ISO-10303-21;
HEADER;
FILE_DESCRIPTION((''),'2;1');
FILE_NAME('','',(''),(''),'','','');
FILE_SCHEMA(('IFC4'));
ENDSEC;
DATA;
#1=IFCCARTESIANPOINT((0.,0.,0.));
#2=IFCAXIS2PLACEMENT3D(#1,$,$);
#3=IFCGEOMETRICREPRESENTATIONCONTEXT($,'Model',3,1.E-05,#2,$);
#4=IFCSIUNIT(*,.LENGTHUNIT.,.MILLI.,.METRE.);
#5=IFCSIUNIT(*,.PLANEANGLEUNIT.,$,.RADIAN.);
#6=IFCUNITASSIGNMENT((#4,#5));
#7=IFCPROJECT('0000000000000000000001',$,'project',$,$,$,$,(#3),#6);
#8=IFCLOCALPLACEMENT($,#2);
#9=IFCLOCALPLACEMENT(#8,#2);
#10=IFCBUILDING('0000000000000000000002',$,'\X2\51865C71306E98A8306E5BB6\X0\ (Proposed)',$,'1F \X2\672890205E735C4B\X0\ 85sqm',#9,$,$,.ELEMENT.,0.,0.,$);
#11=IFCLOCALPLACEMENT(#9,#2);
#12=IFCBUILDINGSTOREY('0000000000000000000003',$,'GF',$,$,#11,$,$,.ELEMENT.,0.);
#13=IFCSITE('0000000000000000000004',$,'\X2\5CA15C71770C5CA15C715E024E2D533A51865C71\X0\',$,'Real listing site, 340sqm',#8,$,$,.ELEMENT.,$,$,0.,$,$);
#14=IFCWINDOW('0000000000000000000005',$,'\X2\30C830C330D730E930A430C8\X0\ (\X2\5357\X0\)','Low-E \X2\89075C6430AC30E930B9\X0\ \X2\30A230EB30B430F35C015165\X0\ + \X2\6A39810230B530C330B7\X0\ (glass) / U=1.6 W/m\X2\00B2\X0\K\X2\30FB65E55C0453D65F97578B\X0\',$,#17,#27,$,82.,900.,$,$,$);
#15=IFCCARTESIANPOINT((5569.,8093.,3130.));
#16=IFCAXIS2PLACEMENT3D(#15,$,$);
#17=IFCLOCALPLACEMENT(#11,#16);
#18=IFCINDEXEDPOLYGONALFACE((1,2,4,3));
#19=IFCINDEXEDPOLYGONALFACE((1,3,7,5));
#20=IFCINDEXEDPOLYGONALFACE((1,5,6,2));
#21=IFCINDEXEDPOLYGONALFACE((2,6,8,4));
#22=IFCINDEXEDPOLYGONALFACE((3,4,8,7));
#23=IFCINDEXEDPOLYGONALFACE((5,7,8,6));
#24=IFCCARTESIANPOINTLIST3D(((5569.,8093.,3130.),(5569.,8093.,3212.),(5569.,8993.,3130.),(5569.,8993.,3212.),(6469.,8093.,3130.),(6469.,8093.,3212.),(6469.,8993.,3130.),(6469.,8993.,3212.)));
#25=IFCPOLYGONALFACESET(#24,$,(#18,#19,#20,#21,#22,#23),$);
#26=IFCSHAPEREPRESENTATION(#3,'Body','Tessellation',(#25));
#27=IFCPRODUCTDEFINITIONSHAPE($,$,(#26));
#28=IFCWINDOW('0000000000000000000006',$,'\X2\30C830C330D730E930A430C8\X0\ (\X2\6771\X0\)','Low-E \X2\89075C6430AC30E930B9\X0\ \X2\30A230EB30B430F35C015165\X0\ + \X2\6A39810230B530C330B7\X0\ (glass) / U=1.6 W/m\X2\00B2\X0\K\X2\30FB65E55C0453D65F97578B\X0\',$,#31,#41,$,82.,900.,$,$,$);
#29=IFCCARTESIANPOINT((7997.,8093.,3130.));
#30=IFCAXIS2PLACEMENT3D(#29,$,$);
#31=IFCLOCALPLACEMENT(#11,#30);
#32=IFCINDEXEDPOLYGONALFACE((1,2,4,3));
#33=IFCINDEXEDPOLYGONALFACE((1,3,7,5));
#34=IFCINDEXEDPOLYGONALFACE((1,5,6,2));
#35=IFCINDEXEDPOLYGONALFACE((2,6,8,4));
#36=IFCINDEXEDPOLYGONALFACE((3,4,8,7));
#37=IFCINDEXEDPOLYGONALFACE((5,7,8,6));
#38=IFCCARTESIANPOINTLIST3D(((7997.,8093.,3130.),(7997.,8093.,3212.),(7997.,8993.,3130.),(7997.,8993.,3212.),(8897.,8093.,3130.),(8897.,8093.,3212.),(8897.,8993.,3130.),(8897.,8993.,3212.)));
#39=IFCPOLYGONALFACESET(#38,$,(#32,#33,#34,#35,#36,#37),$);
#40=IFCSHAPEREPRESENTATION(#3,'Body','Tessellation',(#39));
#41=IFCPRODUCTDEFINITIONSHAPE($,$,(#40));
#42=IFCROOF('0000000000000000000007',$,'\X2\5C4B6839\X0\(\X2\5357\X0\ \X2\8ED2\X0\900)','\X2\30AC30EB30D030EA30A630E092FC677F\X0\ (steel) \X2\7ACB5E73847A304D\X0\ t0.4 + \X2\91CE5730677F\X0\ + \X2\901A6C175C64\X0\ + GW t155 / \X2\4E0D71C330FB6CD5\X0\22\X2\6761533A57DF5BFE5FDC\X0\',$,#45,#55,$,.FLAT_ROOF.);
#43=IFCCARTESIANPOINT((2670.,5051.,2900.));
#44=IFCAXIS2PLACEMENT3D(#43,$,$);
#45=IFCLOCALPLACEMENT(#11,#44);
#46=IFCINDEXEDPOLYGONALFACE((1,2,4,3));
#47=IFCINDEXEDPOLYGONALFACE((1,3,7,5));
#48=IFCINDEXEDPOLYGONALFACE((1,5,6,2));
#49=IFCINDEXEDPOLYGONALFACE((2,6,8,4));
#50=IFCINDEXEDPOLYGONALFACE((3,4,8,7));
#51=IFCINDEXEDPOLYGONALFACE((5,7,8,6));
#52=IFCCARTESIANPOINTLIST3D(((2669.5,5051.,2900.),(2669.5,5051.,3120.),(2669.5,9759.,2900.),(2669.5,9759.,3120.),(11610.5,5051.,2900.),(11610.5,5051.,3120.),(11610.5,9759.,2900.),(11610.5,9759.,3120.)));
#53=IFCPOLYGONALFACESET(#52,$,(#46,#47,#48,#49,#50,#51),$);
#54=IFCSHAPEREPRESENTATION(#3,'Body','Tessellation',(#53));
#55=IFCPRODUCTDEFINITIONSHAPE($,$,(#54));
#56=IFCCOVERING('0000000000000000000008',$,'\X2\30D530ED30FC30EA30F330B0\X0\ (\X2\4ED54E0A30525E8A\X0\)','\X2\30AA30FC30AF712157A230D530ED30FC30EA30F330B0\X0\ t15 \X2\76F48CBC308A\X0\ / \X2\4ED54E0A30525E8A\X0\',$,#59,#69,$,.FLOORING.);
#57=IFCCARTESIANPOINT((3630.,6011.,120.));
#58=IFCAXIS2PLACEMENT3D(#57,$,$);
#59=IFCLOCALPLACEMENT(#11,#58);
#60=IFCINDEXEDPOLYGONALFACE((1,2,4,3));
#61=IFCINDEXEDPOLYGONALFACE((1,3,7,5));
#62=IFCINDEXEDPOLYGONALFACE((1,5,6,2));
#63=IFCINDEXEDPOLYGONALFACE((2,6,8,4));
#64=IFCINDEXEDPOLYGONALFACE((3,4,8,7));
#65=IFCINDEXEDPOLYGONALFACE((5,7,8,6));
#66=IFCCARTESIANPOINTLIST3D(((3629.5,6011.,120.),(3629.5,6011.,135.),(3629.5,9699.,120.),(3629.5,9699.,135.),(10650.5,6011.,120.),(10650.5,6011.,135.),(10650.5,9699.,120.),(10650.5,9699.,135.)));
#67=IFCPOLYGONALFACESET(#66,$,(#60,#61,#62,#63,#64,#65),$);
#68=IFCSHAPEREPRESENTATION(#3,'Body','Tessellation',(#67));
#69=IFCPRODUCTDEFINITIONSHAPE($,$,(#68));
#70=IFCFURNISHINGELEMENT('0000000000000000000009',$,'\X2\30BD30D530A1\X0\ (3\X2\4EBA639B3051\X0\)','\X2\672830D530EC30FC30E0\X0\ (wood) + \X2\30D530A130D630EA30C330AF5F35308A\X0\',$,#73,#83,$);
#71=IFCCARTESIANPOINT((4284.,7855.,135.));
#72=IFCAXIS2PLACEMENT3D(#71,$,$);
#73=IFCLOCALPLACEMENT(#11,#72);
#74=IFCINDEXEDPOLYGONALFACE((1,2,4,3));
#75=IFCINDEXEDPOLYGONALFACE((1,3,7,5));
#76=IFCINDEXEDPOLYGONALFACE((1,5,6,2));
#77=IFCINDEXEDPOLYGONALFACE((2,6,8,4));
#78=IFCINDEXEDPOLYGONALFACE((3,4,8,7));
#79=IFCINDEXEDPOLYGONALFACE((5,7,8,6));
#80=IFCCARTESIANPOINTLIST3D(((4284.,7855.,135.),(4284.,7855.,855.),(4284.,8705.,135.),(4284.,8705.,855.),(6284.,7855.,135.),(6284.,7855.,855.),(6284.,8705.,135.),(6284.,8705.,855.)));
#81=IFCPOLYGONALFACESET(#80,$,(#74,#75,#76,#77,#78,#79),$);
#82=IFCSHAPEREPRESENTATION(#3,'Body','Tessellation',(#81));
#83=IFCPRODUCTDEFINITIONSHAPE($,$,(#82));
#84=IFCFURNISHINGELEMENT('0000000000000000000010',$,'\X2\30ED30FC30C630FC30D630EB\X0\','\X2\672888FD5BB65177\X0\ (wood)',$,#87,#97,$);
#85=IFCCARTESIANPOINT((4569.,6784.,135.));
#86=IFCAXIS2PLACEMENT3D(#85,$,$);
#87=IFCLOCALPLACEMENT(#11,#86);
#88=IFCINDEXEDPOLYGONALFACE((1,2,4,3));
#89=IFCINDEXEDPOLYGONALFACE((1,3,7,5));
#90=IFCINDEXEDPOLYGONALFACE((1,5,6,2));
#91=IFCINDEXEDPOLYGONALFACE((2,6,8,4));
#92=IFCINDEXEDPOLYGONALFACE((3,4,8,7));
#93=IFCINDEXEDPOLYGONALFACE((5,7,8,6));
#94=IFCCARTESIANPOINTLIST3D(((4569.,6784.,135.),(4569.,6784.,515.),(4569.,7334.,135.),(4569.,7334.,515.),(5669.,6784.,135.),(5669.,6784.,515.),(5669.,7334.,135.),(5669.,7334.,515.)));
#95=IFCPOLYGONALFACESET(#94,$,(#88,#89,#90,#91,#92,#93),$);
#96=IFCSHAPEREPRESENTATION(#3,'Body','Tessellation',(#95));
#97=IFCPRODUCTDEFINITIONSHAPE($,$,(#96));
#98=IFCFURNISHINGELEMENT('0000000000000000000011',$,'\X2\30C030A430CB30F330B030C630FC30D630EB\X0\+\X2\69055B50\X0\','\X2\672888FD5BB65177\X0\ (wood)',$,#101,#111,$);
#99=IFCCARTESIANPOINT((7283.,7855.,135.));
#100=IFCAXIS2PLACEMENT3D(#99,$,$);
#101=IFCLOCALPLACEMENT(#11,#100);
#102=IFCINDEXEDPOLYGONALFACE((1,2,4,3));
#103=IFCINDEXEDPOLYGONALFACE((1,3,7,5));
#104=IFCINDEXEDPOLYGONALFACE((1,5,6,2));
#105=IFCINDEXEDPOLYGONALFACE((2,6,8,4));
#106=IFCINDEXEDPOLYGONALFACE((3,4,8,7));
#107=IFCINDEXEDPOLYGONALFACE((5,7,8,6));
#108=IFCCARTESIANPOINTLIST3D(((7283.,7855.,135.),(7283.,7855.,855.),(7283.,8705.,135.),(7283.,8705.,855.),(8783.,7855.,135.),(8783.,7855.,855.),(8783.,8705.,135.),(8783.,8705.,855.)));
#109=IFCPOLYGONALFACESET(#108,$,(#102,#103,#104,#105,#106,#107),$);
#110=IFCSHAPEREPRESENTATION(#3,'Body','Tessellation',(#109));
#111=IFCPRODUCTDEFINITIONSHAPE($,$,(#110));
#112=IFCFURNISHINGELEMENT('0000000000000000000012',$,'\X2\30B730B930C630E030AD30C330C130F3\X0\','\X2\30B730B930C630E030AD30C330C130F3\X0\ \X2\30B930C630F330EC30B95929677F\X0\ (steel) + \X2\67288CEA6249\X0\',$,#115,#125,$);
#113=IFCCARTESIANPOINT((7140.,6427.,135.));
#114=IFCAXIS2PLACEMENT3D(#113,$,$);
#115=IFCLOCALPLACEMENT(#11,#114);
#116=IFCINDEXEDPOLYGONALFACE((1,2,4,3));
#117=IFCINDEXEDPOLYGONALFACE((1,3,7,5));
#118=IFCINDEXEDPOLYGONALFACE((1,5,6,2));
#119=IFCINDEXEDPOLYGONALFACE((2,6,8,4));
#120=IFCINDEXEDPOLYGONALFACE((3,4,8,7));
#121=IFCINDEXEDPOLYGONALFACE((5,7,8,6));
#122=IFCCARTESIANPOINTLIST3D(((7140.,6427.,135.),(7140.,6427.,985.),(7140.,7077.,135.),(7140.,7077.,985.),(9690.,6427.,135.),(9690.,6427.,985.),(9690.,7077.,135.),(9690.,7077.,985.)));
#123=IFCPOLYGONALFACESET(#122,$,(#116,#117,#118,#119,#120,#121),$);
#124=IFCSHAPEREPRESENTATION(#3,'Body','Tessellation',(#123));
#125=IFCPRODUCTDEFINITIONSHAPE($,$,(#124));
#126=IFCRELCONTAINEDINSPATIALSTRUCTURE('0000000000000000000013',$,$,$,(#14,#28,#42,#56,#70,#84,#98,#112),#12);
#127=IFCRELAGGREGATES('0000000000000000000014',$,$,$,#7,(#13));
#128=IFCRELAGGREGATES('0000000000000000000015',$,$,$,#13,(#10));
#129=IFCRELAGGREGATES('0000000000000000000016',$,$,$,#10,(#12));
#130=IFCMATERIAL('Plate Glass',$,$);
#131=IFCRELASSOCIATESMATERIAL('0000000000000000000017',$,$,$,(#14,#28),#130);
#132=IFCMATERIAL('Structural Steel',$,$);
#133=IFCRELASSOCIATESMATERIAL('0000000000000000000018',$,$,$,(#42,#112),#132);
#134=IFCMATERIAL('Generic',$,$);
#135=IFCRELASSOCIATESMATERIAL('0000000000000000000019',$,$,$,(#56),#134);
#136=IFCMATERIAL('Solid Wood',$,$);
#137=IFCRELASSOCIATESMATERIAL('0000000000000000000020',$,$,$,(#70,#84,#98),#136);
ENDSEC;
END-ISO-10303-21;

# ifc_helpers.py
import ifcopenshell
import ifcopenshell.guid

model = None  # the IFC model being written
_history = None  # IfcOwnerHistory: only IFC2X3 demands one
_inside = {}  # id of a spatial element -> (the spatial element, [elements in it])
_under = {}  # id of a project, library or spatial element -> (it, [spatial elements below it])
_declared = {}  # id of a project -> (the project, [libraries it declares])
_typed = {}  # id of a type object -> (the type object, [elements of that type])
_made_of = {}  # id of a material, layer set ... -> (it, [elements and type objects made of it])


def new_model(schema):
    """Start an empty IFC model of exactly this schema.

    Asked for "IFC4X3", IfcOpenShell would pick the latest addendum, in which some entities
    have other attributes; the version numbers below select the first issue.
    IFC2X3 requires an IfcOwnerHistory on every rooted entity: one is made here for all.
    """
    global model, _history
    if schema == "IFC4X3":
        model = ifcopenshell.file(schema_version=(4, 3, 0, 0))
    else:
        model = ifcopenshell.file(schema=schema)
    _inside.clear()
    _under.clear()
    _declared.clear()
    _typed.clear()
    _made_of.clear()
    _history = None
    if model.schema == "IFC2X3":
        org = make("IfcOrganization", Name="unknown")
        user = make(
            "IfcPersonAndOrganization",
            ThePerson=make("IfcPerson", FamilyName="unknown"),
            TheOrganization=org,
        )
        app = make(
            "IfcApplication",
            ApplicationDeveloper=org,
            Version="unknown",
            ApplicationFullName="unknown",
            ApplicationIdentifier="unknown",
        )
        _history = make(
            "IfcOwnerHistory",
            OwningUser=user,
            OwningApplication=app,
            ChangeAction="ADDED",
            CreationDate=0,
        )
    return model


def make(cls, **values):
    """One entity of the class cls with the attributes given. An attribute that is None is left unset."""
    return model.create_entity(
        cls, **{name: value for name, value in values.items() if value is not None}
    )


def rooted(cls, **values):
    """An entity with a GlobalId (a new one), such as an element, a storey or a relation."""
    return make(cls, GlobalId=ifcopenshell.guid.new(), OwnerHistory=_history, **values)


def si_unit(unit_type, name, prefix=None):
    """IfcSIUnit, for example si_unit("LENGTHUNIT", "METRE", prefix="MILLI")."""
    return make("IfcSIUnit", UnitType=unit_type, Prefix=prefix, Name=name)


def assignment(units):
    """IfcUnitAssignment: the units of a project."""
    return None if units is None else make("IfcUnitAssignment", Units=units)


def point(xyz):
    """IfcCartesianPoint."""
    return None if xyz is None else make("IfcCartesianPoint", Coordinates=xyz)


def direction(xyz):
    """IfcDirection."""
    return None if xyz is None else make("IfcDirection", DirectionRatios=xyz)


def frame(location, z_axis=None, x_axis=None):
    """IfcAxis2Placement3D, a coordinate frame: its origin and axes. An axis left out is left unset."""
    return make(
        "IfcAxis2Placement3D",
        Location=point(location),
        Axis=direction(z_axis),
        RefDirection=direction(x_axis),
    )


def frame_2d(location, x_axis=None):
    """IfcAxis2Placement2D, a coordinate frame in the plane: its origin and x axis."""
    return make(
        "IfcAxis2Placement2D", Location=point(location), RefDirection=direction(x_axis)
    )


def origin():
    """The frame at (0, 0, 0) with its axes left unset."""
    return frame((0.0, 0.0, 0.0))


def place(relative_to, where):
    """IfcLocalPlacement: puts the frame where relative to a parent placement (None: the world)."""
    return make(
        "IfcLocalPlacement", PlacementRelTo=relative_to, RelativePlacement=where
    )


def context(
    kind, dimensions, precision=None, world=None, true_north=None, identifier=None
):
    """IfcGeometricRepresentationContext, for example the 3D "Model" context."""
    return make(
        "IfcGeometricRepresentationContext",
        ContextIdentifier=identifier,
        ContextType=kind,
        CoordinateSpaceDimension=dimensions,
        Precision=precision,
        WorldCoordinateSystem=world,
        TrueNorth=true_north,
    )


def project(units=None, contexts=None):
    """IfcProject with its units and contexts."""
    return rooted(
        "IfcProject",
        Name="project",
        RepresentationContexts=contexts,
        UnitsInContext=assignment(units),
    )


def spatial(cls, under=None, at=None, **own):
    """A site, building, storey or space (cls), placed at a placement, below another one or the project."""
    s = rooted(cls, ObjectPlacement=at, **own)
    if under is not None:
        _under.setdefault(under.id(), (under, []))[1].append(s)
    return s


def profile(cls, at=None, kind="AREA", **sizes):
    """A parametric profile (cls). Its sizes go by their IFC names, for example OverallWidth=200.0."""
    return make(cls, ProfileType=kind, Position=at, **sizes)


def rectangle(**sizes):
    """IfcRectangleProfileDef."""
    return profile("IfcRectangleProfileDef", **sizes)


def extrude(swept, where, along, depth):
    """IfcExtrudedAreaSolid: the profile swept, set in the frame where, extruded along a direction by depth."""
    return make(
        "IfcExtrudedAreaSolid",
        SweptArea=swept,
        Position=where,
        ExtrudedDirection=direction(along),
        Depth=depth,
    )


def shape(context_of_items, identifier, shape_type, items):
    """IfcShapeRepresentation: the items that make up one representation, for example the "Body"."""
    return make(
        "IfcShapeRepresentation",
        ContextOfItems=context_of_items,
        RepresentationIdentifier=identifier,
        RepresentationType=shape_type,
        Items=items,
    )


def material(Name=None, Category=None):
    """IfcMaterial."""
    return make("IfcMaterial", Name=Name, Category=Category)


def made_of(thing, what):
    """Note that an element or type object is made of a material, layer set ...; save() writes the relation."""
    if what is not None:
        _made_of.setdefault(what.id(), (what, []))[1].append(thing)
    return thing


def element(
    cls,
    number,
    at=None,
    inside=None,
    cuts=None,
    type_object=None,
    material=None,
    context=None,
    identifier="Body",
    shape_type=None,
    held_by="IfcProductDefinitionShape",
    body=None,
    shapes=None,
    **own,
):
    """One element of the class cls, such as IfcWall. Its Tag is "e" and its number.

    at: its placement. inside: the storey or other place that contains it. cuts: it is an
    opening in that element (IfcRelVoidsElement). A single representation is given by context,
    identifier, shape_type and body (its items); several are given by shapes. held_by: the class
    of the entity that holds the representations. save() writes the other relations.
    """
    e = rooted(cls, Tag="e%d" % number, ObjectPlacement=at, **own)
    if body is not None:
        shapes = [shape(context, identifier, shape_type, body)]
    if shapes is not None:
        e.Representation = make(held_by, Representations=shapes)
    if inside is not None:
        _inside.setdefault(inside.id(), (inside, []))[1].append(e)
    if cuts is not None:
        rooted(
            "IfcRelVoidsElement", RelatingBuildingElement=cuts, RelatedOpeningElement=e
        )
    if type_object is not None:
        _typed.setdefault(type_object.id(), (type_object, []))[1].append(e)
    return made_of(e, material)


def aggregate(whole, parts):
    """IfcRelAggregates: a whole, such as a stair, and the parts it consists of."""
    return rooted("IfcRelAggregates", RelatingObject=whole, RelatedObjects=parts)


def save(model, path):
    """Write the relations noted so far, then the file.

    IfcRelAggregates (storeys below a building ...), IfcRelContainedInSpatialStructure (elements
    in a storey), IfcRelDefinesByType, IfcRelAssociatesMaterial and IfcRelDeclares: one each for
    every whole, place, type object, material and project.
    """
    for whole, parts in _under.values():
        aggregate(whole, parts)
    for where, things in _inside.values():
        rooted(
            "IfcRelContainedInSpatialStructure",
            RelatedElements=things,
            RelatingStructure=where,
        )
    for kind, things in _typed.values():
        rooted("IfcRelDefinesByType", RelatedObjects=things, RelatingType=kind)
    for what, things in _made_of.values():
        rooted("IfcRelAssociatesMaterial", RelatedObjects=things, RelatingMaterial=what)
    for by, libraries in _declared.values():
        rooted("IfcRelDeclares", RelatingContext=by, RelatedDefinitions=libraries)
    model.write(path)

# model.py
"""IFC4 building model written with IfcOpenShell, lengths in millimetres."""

from ifc_helpers import new_model, si_unit, frame, frame_2d, origin, place, context, project, spatial, rectangle, extrude, material, element, save


model = new_model("IFC4")

# Units and contexts
model_context = context("Model", 3, precision=1e-05, world=origin())
ifc_project = project(units=[si_unit("LENGTHUNIT", "METRE", prefix="MILLI"), si_unit("PLANEANGLEUNIT", "RADIAN")], contexts=[model_context])

# Site, building, storey
site_placement = place(None, origin())
site = spatial("IfcSite", under=ifc_project, at=site_placement, Name="岡山県岡山市中区円山", ObjectType="Real listing site, 340sqm", CompositionType="ELEMENT", RefElevation=0.0)
building_placement = place(site_placement, origin())
building = spatial("IfcBuilding", under=site, at=building_placement, Name="円山の風の家 (Proposed)", ObjectType="1F 木造平屋 85sqm", CompositionType="ELEMENT", ElevationOfRefHeight=0.0, ElevationOfTerrain=0.0)
storey_placement = place(building_placement, origin())
storey = spatial("IfcBuildingStorey", under=building, at=storey_placement, Name="GF", CompositionType="ELEMENT", Elevation=0.0)

# Shared definitions
ifc_material_1 = material(Name="Solid Wood")

# Shared definitions
ifc_material_2 = material(Name="Plate Glass")

# Windows
window_1_placement = place(storey_placement, frame((5569.0, 8093.0, 3130.0)))
element("IfcWindow", 1, at=window_1_placement, inside=storey, material=ifc_material_2, Name="トップライト (南)", Description="Low-E 複層ガラス アルゴン封入 + 樹脂サッシ (glass) / U=1.6 W/m²K・日射取得型", OverallHeight=82.0, OverallWidth=900.0, context=model_context, shape_type="SweptSolid", body=[
    extrude(rectangle(XDim=900.0, YDim=900.0, at=frame_2d((450.0, 450.0))), frame((5569.0, 8093.0, 3130.0)), (0.0, 0.0, 1.0), 82.0),
])
window_2_placement = place(storey_placement, frame((7997.0, 8093.0, 3130.0)))
element("IfcWindow", 2, at=window_2_placement, inside=storey, material=ifc_material_2, Name="トップライト (東)", Description="Low-E 複層ガラス アルゴン封入 + 樹脂サッシ (glass) / U=1.6 W/m²K・日射取得型", OverallHeight=82.0, OverallWidth=900.0, context=model_context, shape_type="SweptSolid", body=[
    extrude(rectangle(XDim=900.0, YDim=900.0, at=frame_2d((450.0, 450.0))), frame((7997.0, 8093.0, 3130.0)), (0.0, 0.0, 1.0), 82.0),
])

# Roof
ifc_material_3 = material(Name="Structural Steel")
roof_placement = place(storey_placement, frame((2670.0, 5051.0, 2900.0)))
element("IfcRoof", 3, at=roof_placement, inside=storey, material=ifc_material_3, Name="屋根(南 軒900)", Description="ガルバリウム鋼板 (steel) 立平葺き t0.4 + 野地板 + 通気層 + GW t155 / 不燃・法22条区域対応", PredefinedType="FLAT_ROOF", context=model_context, shape_type="SweptSolid", body=[
    extrude(rectangle(XDim=8941.0, YDim=4708.0, at=frame_2d((4470.0, 2354.0))), frame((2670.0, 5051.0, 2900.0)), (0.0, 0.0, 1.0), 220.0),
])

# Covering
ifc_material_4 = material(Name="Generic")
covering_placement = place(storey_placement, frame((3630.0, 6011.0, 120.0)))
element("IfcCovering", 4, at=covering_placement, inside=storey, material=ifc_material_4, Name="フローリング (仕上げ床)", Description="オーク無垢フローリング t15 直貼り / 仕上げ床", PredefinedType="FLOORING", context=model_context, shape_type="SweptSolid", body=[
    extrude(rectangle(XDim=7021.0, YDim=3688.0, at=frame_2d((3510.0, 1844.0))), frame((3630.0, 6011.0, 120.0)), (0.0, 0.0, 1.0), 15.0),
])

# Furnishing elements
furnishing_1_placement = place(storey_placement, frame((4284.0, 7855.0, 135.0)))
element("IfcFurnishingElement", 5, at=furnishing_1_placement, inside=storey, material=ifc_material_1, Name="ソファ (3人掛け)", Description="木フレーム (wood) + ファブリック張り", context=model_context, shape_type="SweptSolid", body=[
    extrude(rectangle(XDim=2000.0, YDim=850.0, at=frame_2d((1000.0, 425.0))), frame((4284.0, 7855.0, 135.0)), (0.0, 0.0, 1.0), 720.0),
])
furnishing_2_placement = place(storey_placement, frame((4569.0, 6784.0, 135.0)))
element("IfcFurnishingElement", 6, at=furnishing_2_placement, inside=storey, material=ifc_material_1, Name="ローテーブル", Description="木製家具 (wood)", context=model_context, shape_type="SweptSolid", body=[
    extrude(rectangle(XDim=1100.0, YDim=550.0, at=frame_2d((550.0, 275.0))), frame((4569.0, 6784.0, 135.0)), (0.0, 0.0, 1.0), 380.0),
])
furnishing_3_placement = place(storey_placement, frame((7283.0, 7855.0, 135.0)))
element("IfcFurnishingElement", 7, at=furnishing_3_placement, inside=storey, material=ifc_material_1, Name="ダイニングテーブル+椅子", Description="木製家具 (wood)", context=model_context, shape_type="SweptSolid", body=[
    extrude(rectangle(XDim=1500.0, YDim=850.0, at=frame_2d((750.0, 425.0))), frame((7283.0, 7855.0, 135.0)), (0.0, 0.0, 1.0), 720.0),
])
furnishing_4_placement = place(storey_placement, frame((7140.0, 6427.0, 135.0)))
element("IfcFurnishingElement", 8, at=furnishing_4_placement, inside=storey, material=ifc_material_3, Name="システムキッチン", Description="システムキッチン ステンレス天板 (steel) + 木質扉", context=model_context, shape_type="SweptSolid", body=[
    extrude(rectangle(XDim=2550.0, YDim=650.0, at=frame_2d((1275.0, 325.0))), frame((7140.0, 6427.0, 135.0)), (0.0, 0.0, 1.0), 850.0),
])

save(model, "model.ifc")
